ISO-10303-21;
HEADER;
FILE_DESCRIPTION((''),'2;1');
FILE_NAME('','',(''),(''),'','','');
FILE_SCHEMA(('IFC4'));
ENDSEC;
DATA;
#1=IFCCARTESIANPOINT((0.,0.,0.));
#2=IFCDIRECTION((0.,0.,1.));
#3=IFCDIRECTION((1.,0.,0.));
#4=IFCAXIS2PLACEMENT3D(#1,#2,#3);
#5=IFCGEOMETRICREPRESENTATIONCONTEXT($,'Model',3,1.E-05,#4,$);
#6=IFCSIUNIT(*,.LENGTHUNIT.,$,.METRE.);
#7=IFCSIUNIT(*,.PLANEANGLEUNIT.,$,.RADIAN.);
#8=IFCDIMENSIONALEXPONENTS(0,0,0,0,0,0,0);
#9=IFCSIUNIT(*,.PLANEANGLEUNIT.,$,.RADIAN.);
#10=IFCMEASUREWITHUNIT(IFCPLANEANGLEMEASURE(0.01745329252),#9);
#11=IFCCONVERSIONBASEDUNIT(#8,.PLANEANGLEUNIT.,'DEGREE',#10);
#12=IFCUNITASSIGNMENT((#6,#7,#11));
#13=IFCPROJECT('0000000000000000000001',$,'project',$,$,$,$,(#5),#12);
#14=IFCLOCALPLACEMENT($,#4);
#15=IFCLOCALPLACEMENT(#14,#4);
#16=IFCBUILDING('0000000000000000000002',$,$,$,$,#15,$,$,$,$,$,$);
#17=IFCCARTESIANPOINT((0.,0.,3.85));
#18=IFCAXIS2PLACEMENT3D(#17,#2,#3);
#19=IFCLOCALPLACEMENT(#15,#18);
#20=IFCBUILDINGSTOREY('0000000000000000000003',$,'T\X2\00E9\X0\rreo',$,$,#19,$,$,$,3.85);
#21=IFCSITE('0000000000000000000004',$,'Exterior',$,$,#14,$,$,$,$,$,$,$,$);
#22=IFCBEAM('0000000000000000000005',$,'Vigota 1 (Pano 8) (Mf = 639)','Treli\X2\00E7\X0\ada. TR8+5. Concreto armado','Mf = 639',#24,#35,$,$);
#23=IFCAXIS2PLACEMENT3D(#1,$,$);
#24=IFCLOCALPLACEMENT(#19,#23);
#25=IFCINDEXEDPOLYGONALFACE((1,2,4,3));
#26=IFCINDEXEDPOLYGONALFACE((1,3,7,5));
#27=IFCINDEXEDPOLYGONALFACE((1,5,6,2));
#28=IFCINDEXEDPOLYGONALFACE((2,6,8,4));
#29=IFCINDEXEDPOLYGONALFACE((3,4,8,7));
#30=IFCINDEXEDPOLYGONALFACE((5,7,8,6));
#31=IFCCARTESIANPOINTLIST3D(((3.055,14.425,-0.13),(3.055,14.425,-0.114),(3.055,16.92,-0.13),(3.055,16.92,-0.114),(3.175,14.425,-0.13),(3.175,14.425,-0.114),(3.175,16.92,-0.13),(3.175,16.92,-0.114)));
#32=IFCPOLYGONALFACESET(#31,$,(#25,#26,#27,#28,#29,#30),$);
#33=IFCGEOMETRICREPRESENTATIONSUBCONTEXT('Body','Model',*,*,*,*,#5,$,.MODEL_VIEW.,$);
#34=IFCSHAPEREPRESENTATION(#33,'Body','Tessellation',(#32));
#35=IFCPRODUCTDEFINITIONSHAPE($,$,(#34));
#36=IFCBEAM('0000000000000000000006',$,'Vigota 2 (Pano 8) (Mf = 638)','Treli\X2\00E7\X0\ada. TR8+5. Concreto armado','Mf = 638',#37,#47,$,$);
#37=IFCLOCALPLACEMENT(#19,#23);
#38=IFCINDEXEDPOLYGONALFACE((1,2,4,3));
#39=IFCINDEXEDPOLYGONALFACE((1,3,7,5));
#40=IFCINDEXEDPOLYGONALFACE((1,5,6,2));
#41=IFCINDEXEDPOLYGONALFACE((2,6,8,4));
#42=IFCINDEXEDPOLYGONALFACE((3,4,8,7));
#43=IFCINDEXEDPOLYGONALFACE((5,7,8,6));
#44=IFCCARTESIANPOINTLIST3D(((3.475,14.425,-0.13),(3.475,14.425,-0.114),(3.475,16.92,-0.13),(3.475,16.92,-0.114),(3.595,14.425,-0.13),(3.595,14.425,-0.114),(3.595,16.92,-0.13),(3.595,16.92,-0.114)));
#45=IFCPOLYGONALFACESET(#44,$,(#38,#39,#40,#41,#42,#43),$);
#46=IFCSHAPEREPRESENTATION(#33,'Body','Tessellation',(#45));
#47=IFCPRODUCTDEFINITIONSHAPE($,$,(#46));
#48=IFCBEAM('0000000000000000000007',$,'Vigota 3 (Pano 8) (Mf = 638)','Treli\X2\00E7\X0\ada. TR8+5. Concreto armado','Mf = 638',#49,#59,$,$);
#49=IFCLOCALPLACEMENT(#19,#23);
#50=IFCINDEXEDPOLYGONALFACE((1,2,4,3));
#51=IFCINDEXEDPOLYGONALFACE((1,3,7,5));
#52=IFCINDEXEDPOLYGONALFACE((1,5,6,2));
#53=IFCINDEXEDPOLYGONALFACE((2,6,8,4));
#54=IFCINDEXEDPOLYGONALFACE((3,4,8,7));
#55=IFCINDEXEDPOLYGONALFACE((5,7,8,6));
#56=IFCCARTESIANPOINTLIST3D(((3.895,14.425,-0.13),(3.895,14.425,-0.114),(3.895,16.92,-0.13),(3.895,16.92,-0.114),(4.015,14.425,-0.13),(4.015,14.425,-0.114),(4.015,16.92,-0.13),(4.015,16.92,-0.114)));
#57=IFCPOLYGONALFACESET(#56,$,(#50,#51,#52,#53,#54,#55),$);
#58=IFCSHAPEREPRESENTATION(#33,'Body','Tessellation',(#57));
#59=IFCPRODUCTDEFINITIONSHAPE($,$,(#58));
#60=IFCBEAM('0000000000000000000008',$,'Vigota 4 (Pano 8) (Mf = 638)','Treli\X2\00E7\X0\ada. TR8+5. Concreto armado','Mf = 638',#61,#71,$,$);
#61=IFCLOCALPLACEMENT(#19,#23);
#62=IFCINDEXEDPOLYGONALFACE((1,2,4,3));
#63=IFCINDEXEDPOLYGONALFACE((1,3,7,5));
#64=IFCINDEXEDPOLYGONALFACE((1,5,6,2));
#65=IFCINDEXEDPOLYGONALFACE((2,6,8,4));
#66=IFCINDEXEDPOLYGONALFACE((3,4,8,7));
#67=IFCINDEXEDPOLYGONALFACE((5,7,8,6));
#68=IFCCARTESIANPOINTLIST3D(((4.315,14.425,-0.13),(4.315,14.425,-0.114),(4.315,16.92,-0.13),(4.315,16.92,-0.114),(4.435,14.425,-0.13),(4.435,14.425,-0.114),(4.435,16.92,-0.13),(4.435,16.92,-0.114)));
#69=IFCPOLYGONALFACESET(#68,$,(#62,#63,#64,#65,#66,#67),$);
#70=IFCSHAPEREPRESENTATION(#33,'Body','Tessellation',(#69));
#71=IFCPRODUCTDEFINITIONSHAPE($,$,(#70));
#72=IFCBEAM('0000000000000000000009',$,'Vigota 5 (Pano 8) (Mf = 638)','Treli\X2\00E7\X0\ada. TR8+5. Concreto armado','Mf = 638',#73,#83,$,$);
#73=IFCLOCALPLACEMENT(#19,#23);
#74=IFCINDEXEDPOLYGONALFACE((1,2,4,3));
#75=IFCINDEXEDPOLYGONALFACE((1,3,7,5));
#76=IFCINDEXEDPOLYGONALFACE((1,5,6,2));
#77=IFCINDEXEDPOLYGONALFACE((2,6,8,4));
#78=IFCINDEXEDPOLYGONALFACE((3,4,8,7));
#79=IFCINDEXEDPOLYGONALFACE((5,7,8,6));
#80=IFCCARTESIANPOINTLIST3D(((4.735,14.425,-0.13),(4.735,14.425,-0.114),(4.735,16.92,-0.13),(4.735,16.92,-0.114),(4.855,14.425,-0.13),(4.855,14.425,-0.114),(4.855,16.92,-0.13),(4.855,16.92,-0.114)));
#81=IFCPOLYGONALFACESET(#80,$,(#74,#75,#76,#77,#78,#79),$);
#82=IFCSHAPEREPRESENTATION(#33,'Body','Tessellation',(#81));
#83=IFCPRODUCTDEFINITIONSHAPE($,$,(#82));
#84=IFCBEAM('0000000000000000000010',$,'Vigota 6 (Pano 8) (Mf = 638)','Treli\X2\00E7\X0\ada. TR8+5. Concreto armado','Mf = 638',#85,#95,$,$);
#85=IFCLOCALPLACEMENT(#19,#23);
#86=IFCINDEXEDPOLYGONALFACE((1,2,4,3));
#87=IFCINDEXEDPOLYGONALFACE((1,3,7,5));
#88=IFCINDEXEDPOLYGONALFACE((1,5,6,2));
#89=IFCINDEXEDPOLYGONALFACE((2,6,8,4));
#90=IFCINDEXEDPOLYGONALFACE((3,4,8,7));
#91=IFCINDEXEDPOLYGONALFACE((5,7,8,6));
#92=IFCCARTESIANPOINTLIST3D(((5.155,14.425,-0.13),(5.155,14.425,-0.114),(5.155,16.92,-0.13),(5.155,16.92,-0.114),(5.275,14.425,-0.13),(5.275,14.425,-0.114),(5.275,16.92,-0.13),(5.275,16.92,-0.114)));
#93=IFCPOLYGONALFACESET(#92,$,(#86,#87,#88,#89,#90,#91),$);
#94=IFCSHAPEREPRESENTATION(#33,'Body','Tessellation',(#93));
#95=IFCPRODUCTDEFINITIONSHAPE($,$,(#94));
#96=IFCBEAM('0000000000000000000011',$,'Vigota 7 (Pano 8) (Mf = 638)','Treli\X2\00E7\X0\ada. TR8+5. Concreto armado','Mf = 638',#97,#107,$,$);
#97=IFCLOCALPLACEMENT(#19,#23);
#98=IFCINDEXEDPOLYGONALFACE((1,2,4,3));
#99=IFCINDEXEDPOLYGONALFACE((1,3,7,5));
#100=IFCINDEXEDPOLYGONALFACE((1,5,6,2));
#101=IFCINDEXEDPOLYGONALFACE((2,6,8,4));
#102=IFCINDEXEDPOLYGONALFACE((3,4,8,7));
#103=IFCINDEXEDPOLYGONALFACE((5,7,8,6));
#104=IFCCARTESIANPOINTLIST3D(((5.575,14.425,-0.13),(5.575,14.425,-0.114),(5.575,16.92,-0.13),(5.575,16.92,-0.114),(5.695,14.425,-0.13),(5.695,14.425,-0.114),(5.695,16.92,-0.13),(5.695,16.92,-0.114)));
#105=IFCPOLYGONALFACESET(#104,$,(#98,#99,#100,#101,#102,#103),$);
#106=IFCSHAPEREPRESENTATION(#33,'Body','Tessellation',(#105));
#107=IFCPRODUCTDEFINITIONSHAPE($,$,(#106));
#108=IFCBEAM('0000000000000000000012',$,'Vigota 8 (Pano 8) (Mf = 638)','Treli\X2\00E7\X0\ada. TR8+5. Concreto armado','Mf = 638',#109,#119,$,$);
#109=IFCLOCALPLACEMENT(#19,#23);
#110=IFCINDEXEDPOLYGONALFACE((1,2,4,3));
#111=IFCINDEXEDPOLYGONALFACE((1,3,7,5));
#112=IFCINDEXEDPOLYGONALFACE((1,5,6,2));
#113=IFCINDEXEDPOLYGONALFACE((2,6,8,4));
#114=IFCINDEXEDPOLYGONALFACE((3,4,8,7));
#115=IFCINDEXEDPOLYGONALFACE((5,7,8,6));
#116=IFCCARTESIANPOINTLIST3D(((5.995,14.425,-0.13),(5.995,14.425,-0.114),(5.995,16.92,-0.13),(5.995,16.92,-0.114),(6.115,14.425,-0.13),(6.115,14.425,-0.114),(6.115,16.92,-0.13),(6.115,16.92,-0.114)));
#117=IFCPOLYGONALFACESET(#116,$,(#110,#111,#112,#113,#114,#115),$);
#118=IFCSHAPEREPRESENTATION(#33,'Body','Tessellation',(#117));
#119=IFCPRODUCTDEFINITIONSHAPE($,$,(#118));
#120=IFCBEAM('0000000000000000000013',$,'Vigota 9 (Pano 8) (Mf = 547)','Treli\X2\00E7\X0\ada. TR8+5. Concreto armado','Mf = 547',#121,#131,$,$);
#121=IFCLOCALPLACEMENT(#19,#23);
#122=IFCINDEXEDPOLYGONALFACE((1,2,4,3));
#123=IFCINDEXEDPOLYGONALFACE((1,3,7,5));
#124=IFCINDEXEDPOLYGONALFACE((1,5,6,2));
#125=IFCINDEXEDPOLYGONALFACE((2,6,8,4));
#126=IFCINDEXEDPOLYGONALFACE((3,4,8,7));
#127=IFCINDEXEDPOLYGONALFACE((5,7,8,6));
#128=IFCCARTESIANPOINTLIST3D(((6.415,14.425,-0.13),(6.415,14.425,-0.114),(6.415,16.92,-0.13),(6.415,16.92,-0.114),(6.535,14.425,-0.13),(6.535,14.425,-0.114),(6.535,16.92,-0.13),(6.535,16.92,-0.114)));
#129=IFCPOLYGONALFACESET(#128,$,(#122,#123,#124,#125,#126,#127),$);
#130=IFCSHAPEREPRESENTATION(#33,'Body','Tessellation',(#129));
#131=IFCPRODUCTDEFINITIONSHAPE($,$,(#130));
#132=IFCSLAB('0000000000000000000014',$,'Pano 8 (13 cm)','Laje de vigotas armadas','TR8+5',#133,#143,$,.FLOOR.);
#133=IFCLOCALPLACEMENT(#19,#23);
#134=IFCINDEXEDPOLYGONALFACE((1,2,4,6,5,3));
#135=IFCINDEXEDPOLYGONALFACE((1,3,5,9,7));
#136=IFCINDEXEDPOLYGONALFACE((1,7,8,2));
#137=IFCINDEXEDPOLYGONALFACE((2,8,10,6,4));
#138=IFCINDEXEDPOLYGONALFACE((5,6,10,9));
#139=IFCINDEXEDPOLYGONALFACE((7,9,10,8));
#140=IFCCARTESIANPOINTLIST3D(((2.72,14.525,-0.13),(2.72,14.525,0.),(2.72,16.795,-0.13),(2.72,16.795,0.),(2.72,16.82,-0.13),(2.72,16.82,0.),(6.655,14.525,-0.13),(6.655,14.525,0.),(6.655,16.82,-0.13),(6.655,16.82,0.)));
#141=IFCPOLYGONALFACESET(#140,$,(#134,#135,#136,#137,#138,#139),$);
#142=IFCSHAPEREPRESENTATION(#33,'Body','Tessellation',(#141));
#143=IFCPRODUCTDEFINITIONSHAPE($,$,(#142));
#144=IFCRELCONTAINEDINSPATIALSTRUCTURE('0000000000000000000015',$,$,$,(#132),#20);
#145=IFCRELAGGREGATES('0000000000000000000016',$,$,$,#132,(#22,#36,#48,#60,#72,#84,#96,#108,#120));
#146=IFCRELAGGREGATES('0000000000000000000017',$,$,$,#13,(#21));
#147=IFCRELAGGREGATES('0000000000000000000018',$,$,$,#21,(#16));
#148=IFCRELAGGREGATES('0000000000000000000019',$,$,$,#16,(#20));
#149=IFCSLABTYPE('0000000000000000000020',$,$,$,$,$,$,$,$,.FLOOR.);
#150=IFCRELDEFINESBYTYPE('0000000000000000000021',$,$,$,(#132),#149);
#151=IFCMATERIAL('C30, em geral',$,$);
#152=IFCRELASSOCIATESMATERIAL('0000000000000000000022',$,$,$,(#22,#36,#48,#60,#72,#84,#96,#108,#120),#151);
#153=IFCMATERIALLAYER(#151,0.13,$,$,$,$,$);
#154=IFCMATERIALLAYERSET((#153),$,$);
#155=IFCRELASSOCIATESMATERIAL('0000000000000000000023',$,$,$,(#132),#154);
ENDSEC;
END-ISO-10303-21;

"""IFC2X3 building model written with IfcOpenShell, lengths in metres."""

from ifc_helpers import new_model, entity, si_unit, converted_unit, frame, origin_with_axes, place, context, subcontext, project, spatial, polyline, outline, extrude, material, layer, layer_set, layer_usage, type_object, element, aggregate, save


model = new_model("IFC2X3")

# Units and contexts
model_context = context("Model", 3, precision=1e-05, world=origin_with_axes())
body_context = subcontext(model_context, "Body", "Model", "MODEL_VIEW")
ifc_project = project(units=[si_unit("LENGTHUNIT", "METRE"), si_unit("PLANEANGLEUNIT", "RADIAN"), converted_unit("PLANEANGLEUNIT", "DEGREE", entity("IfcPlaneAngleMeasure", 0.01745329252), si_unit("PLANEANGLEUNIT", "RADIAN"), dimensions=[0, 0, 0, 0, 0, 0, 0])], contexts=[model_context])

# Beams
ifc_material = material(Name="C30, em geral")
site_placement = place(None, origin_with_axes())
building_placement = place(site_placement, origin_with_axes())
storey_placement = place(building_placement, frame((0.0, 0.0, 3.85), z_axis=(0.0, 0.0, 1.0), x_axis=(1.0, 0.0, 0.0)))
beam_1_placement = place(storey_placement, frame((3.115, 14.425, -0.122), z_axis=(0.0, 1.0, 0.0), x_axis=(-1.0, 0.0, 0.0)))
beam_1 = element("IfcBeam", 1, at=beam_1_placement, material=ifc_material, Name="Vigota 1 (Pano 8) (Mf = 639)", Description="Treliçada. TR8+5. Concreto armado", ObjectType="Mf = 639", context=body_context, shape_type="SweptSolid", body=[
    extrude(outline(polyline([(0.06, 0.008), (-0.06, 0.008), (-0.06, -0.008), (0.06, -0.008), (0.06, 0.008)])), origin_with_axes(), (0.0, 0.0, 1.0), 2.495),
])
beam_2_placement = place(storey_placement, frame((3.535, 14.425, -0.122), z_axis=(0.0, 1.0, 0.0), x_axis=(-1.0, 0.0, 0.0)))
beam_2 = element("IfcBeam", 2, at=beam_2_placement, material=ifc_material, Name="Vigota 2 (Pano 8) (Mf = 638)", Description="Treliçada. TR8+5. Concreto armado", ObjectType="Mf = 638", context=body_context, shape_type="SweptSolid", body=[
    extrude(outline(polyline([(0.06, 0.008), (-0.06, 0.008), (-0.06, -0.008), (0.06, -0.008), (0.06, 0.008)])), origin_with_axes(), (0.0, 0.0, 1.0), 2.495),
])
beam_3_placement = place(storey_placement, frame((3.955, 14.425, -0.122), z_axis=(0.0, 1.0, 0.0), x_axis=(-1.0, 0.0, 0.0)))
beam_3 = element("IfcBeam", 3, at=beam_3_placement, material=ifc_material, Name="Vigota 3 (Pano 8) (Mf = 638)", Description="Treliçada. TR8+5. Concreto armado", ObjectType="Mf = 638", context=body_context, shape_type="SweptSolid", body=[
    extrude(outline(polyline([(0.06, 0.008), (-0.06, 0.008), (-0.06, -0.008), (0.06, -0.008), (0.06, 0.008)])), origin_with_axes(), (0.0, 0.0, 1.0), 2.495),
])
beam_4_placement = place(storey_placement, frame((4.375, 14.425, -0.122), z_axis=(0.0, 1.0, 0.0), x_axis=(-1.0, 0.0, 0.0)))
beam_4 = element("IfcBeam", 4, at=beam_4_placement, material=ifc_material, Name="Vigota 4 (Pano 8) (Mf = 638)", Description="Treliçada. TR8+5. Concreto armado", ObjectType="Mf = 638", context=body_context, shape_type="SweptSolid", body=[
    extrude(outline(polyline([(0.06, 0.008), (-0.06, 0.008), (-0.06, -0.008), (0.06, -0.008), (0.06, 0.008)])), origin_with_axes(), (0.0, 0.0, 1.0), 2.495),
])
beam_5_placement = place(storey_placement, frame((4.795, 14.425, -0.122), z_axis=(0.0, 1.0, 0.0), x_axis=(-1.0, 0.0, 0.0)))
beam_5 = element("IfcBeam", 5, at=beam_5_placement, material=ifc_material, Name="Vigota 5 (Pano 8) (Mf = 638)", Description="Treliçada. TR8+5. Concreto armado", ObjectType="Mf = 638", context=body_context, shape_type="SweptSolid", body=[
    extrude(outline(polyline([(0.06, 0.008), (-0.06, 0.008), (-0.06, -0.008), (0.06, -0.008), (0.06, 0.008)])), origin_with_axes(), (0.0, 0.0, 1.0), 2.495),
])
beam_6_placement = place(storey_placement, frame((5.215, 14.425, -0.122), z_axis=(0.0, 1.0, 0.0), x_axis=(-1.0, 0.0, 0.0)))
beam_6 = element("IfcBeam", 6, at=beam_6_placement, material=ifc_material, Name="Vigota 6 (Pano 8) (Mf = 638)", Description="Treliçada. TR8+5. Concreto armado", ObjectType="Mf = 638", context=body_context, shape_type="SweptSolid", body=[
    extrude(outline(polyline([(0.06, 0.008), (-0.06, 0.008), (-0.06, -0.008), (0.06, -0.008), (0.06, 0.008)])), origin_with_axes(), (0.0, 0.0, 1.0), 2.495),
])
beam_7_placement = place(storey_placement, frame((5.635, 14.425, -0.122), z_axis=(0.0, 1.0, 0.0), x_axis=(-1.0, 0.0, 0.0)))
beam_7 = element("IfcBeam", 7, at=beam_7_placement, material=ifc_material, Name="Vigota 7 (Pano 8) (Mf = 638)", Description="Treliçada. TR8+5. Concreto armado", ObjectType="Mf = 638", context=body_context, shape_type="SweptSolid", body=[
    extrude(outline(polyline([(0.06, 0.008), (-0.06, 0.008), (-0.06, -0.008), (0.06, -0.008), (0.06, 0.008)])), origin_with_axes(), (0.0, 0.0, 1.0), 2.495),
])
beam_8_placement = place(storey_placement, frame((6.055, 14.425, -0.122), z_axis=(0.0, 1.0, 0.0), x_axis=(-1.0, 0.0, 0.0)))
beam_8 = element("IfcBeam", 8, at=beam_8_placement, material=ifc_material, Name="Vigota 8 (Pano 8) (Mf = 638)", Description="Treliçada. TR8+5. Concreto armado", ObjectType="Mf = 638", context=body_context, shape_type="SweptSolid", body=[
    extrude(outline(polyline([(0.06, 0.008), (-0.06, 0.008), (-0.06, -0.008), (0.06, -0.008), (0.06, 0.008)])), origin_with_axes(), (0.0, 0.0, 1.0), 2.495),
])
beam_9_placement = place(storey_placement, frame((6.475, 14.425, -0.122), z_axis=(0.0, 1.0, 0.0), x_axis=(-1.0, 0.0, 0.0)))
beam_9 = element("IfcBeam", 9, at=beam_9_placement, material=ifc_material, Name="Vigota 9 (Pano 8) (Mf = 547)", Description="Treliçada. TR8+5. Concreto armado", ObjectType="Mf = 547", context=body_context, shape_type="SweptSolid", body=[
    extrude(outline(polyline([(0.06, 0.008), (-0.06, 0.008), (-0.06, -0.008), (0.06, -0.008), (0.06, 0.008)])), origin_with_axes(), (0.0, 0.0, 1.0), 2.495),
])

# Site, building, storey
site = spatial("IfcSite", under=ifc_project, at=site_placement, Name="Exterior")
building = spatial("IfcBuilding", under=site, at=building_placement)
storey = spatial("IfcBuildingStorey", under=building, at=storey_placement, Name="Térreo", Elevation=3.85)

# Slab
ifc_layer_1 = layer(ifc_material, 0.13)
ifc_layer_set_1 = layer_set([ifc_layer_1])
ifc_layer_usage_1 = layer_usage(ifc_layer_set_1, "AXIS3", "POSITIVE", 0.0)
slab_type = type_object("IfcSlabType", PredefinedType="FLOOR")
slab_1_placement = place(storey_placement, frame((0.0, 0.0, -0.13), z_axis=(0.0, 0.0, 1.0), x_axis=(1.0, 0.0, 0.0)))
slab_1 = element("IfcSlab", 10, at=slab_1_placement, inside=storey, type_object=slab_type, material=ifc_layer_usage_1, Name="Pano 8 (13 cm)", Description="Laje de vigotas armadas", ObjectType="TR8+5", PredefinedType="FLOOR", context=body_context, shape_type="SweptSolid", body=[
    extrude(outline(polyline([(6.655, 14.525), (6.655, 16.82), (2.72, 16.82), (2.72, 16.795), (2.72, 14.525), (6.655, 14.525)])), origin_with_axes(), (0.0, 0.0, 1.0), 0.13),
])
aggregate(slab_1, [beam_1, beam_2, beam_3, beam_4, beam_5, beam_6, beam_7, beam_8, beam_9])

save(model, "model.ifc")
